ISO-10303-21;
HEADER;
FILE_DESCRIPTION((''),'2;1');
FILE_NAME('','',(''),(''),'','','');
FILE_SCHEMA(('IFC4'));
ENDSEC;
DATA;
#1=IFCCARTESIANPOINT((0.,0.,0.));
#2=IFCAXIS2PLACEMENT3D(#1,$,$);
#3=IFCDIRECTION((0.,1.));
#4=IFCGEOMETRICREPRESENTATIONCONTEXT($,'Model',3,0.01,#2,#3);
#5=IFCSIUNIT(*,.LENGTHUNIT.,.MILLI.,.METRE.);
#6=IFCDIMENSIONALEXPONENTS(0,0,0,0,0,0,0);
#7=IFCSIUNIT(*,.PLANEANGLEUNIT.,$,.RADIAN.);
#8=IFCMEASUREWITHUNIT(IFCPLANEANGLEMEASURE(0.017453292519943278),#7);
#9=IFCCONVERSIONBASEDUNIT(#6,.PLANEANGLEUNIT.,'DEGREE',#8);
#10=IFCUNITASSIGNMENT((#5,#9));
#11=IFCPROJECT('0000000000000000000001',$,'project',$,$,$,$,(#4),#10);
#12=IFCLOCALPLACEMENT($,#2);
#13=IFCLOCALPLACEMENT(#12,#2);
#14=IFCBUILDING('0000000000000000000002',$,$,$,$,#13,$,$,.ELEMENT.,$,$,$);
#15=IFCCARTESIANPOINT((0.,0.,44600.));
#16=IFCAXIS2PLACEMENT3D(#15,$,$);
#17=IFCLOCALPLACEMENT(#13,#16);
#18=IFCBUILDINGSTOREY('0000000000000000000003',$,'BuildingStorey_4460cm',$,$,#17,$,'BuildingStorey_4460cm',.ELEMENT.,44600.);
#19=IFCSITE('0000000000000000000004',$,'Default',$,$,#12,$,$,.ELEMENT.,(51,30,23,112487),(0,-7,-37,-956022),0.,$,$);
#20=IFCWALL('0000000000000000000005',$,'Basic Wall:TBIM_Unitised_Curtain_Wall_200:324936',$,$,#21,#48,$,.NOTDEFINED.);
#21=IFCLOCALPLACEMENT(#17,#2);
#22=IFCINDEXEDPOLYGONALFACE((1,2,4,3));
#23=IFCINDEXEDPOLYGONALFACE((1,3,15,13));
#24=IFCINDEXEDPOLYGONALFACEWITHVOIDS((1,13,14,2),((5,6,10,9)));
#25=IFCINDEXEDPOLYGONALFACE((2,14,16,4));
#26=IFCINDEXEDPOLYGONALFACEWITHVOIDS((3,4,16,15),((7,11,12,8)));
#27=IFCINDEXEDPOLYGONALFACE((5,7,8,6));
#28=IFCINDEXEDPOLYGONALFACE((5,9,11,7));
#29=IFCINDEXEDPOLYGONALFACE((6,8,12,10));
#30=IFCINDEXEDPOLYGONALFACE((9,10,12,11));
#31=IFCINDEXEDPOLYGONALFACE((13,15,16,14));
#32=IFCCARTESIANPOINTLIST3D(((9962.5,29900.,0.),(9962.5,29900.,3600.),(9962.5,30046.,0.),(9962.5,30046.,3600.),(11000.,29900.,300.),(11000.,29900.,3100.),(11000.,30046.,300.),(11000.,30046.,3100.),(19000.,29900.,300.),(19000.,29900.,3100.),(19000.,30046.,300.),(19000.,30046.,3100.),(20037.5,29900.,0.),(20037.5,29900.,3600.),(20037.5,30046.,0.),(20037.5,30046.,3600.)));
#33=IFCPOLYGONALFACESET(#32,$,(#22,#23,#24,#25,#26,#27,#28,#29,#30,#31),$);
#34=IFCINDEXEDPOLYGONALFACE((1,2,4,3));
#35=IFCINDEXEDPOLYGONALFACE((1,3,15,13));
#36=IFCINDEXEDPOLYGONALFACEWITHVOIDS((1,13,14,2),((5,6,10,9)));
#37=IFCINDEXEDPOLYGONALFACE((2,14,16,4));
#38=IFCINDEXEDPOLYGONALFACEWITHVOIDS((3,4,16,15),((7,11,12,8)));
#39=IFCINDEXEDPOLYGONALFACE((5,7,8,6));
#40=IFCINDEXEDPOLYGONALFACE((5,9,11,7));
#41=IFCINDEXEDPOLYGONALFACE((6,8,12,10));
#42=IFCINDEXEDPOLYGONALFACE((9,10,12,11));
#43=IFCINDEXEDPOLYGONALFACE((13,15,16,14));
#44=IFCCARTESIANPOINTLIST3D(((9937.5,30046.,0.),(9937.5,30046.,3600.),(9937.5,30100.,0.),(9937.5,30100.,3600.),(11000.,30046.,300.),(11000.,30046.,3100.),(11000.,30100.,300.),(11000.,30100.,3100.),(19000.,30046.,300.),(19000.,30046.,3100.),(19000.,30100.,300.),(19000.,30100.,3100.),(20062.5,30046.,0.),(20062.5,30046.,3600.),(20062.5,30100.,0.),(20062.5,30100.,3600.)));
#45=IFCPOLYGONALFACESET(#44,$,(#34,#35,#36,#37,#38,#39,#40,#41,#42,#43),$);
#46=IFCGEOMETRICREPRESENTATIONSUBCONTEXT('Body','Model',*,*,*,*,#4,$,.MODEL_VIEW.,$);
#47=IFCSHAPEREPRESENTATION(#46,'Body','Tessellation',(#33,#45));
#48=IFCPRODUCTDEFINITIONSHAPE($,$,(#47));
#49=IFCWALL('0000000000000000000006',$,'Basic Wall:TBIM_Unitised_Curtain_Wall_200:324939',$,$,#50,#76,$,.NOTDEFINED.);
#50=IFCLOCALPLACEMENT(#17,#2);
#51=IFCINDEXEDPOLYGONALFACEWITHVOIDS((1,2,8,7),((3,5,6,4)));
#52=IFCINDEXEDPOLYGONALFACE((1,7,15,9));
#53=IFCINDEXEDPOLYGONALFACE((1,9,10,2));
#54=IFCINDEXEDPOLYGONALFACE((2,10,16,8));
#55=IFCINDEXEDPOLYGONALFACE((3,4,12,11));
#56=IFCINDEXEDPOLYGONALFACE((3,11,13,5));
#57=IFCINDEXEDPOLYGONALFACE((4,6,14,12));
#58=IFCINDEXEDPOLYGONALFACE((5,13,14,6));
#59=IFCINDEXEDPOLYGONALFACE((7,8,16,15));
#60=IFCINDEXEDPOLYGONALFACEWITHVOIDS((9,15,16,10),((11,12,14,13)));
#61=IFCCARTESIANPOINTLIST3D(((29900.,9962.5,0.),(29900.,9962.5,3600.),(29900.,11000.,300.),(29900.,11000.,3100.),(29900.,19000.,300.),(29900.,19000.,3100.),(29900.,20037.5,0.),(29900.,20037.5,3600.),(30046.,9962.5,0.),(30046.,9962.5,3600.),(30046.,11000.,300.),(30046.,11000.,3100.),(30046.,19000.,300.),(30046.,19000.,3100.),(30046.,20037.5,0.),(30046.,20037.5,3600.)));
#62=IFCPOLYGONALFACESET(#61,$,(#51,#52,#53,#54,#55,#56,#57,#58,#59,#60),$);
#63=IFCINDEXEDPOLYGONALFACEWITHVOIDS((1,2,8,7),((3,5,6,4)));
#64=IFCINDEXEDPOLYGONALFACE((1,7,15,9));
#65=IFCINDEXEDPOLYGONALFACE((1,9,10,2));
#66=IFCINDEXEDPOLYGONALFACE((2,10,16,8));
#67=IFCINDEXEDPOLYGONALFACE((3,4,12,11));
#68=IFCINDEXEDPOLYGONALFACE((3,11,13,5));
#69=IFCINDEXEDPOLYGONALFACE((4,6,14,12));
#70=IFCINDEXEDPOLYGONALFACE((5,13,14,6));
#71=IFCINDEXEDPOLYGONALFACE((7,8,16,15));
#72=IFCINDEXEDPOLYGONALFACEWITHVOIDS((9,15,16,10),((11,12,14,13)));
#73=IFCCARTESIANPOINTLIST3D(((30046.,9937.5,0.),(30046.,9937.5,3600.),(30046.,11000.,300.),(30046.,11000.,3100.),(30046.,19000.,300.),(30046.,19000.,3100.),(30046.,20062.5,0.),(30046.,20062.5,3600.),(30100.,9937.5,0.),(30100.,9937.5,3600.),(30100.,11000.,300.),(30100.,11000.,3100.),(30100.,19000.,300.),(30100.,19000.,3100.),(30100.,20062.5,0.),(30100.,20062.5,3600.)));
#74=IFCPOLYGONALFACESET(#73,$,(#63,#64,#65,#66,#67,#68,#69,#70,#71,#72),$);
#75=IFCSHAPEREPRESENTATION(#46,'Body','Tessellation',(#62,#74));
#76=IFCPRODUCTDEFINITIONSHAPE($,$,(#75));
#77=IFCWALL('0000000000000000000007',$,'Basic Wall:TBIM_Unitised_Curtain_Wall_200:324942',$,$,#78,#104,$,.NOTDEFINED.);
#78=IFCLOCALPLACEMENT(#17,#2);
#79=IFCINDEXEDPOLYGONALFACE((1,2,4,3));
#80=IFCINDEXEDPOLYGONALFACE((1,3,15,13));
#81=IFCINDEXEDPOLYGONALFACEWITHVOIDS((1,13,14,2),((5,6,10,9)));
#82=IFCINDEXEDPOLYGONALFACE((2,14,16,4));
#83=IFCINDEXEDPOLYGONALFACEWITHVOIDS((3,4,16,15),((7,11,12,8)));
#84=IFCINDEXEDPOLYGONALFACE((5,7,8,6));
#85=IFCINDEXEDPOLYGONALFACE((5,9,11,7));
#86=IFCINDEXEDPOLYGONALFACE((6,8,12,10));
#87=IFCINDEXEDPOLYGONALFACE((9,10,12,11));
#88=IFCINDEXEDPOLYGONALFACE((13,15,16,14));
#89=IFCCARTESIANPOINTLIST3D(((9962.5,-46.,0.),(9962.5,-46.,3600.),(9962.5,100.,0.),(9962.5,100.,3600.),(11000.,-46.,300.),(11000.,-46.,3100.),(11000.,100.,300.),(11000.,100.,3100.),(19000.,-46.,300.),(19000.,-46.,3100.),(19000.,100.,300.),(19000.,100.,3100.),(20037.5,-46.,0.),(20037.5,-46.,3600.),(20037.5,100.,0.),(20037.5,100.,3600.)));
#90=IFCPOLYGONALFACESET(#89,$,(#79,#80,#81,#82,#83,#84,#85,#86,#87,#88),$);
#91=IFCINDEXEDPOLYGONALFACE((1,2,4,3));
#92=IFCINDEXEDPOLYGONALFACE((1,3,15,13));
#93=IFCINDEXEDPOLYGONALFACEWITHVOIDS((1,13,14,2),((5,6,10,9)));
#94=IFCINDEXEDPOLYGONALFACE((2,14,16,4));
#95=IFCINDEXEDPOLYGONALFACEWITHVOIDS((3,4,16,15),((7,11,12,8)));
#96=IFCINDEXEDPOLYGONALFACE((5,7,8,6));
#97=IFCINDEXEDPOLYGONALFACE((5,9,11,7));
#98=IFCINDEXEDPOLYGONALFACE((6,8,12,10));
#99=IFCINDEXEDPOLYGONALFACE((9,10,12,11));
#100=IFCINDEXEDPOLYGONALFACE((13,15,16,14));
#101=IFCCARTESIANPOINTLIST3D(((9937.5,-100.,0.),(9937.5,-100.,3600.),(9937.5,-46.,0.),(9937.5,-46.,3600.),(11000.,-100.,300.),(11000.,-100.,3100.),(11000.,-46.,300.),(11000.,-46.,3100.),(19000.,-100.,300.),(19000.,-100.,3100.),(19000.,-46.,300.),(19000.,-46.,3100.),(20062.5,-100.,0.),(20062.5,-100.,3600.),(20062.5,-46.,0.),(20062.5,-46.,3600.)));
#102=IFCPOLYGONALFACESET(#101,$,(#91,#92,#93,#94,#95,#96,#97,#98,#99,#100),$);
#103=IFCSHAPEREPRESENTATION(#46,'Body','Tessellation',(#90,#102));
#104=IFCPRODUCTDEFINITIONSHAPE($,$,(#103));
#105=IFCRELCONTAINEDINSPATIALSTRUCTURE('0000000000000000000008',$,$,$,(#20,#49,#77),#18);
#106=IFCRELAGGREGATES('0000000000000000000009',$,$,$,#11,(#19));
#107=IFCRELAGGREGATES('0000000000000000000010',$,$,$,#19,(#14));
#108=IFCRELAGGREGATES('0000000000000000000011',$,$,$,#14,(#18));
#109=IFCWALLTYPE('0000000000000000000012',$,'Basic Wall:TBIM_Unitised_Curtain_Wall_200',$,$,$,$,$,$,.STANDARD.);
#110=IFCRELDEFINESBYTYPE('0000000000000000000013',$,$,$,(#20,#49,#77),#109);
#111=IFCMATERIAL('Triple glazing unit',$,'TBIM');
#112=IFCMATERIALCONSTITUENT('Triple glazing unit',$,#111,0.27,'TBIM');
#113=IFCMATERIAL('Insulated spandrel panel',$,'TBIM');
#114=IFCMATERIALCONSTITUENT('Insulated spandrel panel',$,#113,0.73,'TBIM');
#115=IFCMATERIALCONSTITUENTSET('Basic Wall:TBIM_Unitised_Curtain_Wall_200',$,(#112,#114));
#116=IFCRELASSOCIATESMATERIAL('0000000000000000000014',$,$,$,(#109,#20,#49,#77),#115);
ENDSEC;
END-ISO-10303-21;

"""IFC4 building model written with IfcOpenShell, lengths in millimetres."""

from ifc_helpers import new_model, entity, si_unit, converted_unit, direction, frame, origin, place, context, subcontext, project, spatial, indexed_curve, outline, extrude, material, constituent, constituent_set, type_object, element, save


model = new_model("IFC4")

# Units and contexts
model_context = context("Model", 3, precision=0.01, world=origin(), true_north=direction((0.0, 1.0)))
body_context = subcontext(model_context, "Body", "Model", "MODEL_VIEW")
ifc_project = project(units=[si_unit("LENGTHUNIT", "METRE", prefix="MILLI"), converted_unit("PLANEANGLEUNIT", "DEGREE", entity("IfcPlaneAngleMeasure", 0.017453292519943278), si_unit("PLANEANGLEUNIT", "RADIAN"), dimensions=[0, 0, 0, 0, 0, 0, 0])], contexts=[model_context])

# Site, building, storey
site_placement = place(None, origin())
site = spatial("IfcSite", under=ifc_project, at=site_placement, Name="Default", CompositionType="ELEMENT", RefLatitude=(51, 30, 23, 112487), RefLongitude=(0, -7, -37, -956022), RefElevation=0.0)
building_placement = place(site_placement, origin())
building = spatial("IfcBuilding", under=site, at=building_placement, CompositionType="ELEMENT")
storey_placement = place(building_placement, frame((0.0, 0.0, 44600.0)))
storey = spatial("IfcBuildingStorey", under=building, at=storey_placement, Name="BuildingStorey_4460cm", LongName="BuildingStorey_4460cm", CompositionType="ELEMENT", Elevation=44600.0)

# Walls, openings
ifc_material_1 = material(Name="Triple glazing unit", Category="TBIM")
ifc_constituent_1 = constituent(ifc_material_1, Name="Triple glazing unit", Category="TBIM", fraction=0.27)
ifc_material_2 = material(Name="Insulated spandrel panel", Category="TBIM")
ifc_constituent_2 = constituent(ifc_material_2, Name="Insulated spandrel panel", Category="TBIM", fraction=0.73)
ifc_constituent_set_1 = constituent_set(constituents=[ifc_constituent_1, ifc_constituent_2], Name="Basic Wall:TBIM_Unitised_Curtain_Wall_200")
wall_type_1 = type_object("IfcWallType", Name="Basic Wall:TBIM_Unitised_Curtain_Wall_200", PredefinedType="STANDARD", material=ifc_constituent_set_1)
wall_1_placement = place(storey_placement, frame((9937.5, 30000.0, 0.0)))
wall_1 = element("IfcWall", 1, at=wall_1_placement, inside=storey, type_object=wall_type_1, material=ifc_constituent_set_1, Name="Basic Wall:TBIM_Unitised_Curtain_Wall_200:324936", PredefinedType="NOTDEFINED", context=body_context, shape_type="SweptSolid", body=[
    extrude(outline(indexed_curve([(-1800.0, -5037.5), (1800.0, -5037.5), (1800.0, -4937.5), (1800.0, 4937.5), (1800.0, 5037.5), (-1800.0, 5037.5), (-1800.0, 4937.5), (-1800.0, -4937.5), (-1800.0, -5037.5)], self_intersect=False), holes=[indexed_curve([(1300.0, -4000.0), (-1500.0, -4000.0), (-1500.0, 4000.0), (1300.0, 4000.0), (1300.0, -4000.0)], self_intersect=False)]), frame((5062.5, -100.0, 1800.0), z_axis=(0.0, 1.0, 0.0), x_axis=(0.0, 0.0, 1.0)), (0.0, 0.0, 1.0), 146.0),
    extrude(outline(indexed_curve([(-1800.0, -5062.5), (1800.0, -5062.5), (1800.0, 5062.5), (-1800.0, 5062.5), (-1800.0, -5062.5)], self_intersect=False), holes=[indexed_curve([(-1500.0, -4000.0), (-1500.0, 4000.0), (1300.0, 4000.0), (1300.0, -4000.0), (-1500.0, -4000.0)], self_intersect=False)]), frame((5062.5, 46.0, 1800.0), z_axis=(0.0, 1.0, 0.0), x_axis=(0.0, 0.0, 1.0)), (0.0, 0.0, 1.0), 54.0),
])
opening_1_placement = place(wall_1_placement, frame((1062.5, -100.0, 300.0)))
element("IfcOpeningElement", 2, at=opening_1_placement, cuts=wall_1, PredefinedType="OPENING", context=body_context, shape_type="SweptSolid", body=[
    extrude(outline(indexed_curve([(2800.0, 0.0), (2800.0, 8000.0), (0.0, 8000.0), (0.0, 0.0), (2800.0, 0.0)], self_intersect=False)), frame((0.0, 0.0, 0.0), z_axis=(0.0, 1.0, 0.0), x_axis=(0.0, 0.0, 1.0)), (0.0, 0.0, 1.0), 200.0),
])
wall_2_placement = place(storey_placement, frame((30000.0, 9937.5, 0.0), z_axis=(0.0, 0.0, 1.0), x_axis=(0.0, 1.0, 0.0)))
wall_2 = element("IfcWall", 3, at=wall_2_placement, inside=storey, type_object=wall_type_1, material=ifc_constituent_set_1, Name="Basic Wall:TBIM_Unitised_Curtain_Wall_200:324939", PredefinedType="NOTDEFINED", context=body_context, shape_type="SweptSolid", body=[
    extrude(outline(indexed_curve([(-5037.5, -1800.0), (-4937.5, -1800.0), (4937.5, -1800.0), (5037.5, -1800.0), (5037.5, 1800.0), (4937.5, 1800.0), (-4937.5, 1800.0), (-5037.5, 1800.0), (-5037.5, -1800.0)], self_intersect=False), holes=[indexed_curve([(-4000.0, 1300.0), (4000.0, 1300.0), (4000.0, -1500.0), (-4000.0, -1500.0), (-4000.0, 1300.0)], self_intersect=False)]), frame((5062.5, 100.0, 1800.0), z_axis=(0.0, -1.0, 0.0), x_axis=(1.0, 0.0, 0.0)), (0.0, 0.0, 1.0), 146.0),
    extrude(outline(indexed_curve([(-1800.0, -5062.5), (1800.0, -5062.5), (1800.0, 5062.5), (-1800.0, 5062.5), (-1800.0, -5062.5)], self_intersect=False), holes=[indexed_curve([(1300.0, 4000.0), (1300.0, -4000.0), (-1500.0, -4000.0), (-1500.0, 4000.0), (1300.0, 4000.0)], self_intersect=False)]), frame((5062.5, -46.0, 1800.0), z_axis=(0.0, -1.0, 0.0), x_axis=(0.0, 0.0, 1.0)), (0.0, 0.0, 1.0), 54.0),
])
opening_2_placement = place(wall_2_placement, frame((1062.5, -100.0, 300.0)))
element("IfcOpeningElement", 4, at=opening_2_placement, cuts=wall_2, PredefinedType="OPENING", context=body_context, shape_type="SweptSolid", body=[
    extrude(outline(indexed_curve([(2800.0, 0.0), (2800.0, 8000.0), (0.0, 8000.0), (0.0, 0.0), (2800.0, 0.0)], self_intersect=False)), frame((0.0, 0.0, 0.0), z_axis=(0.0, 1.0, 0.0), x_axis=(0.0, 0.0, 1.0)), (0.0, 0.0, 1.0), 200.0),
])
wall_3_placement = place(storey_placement, frame((9937.5, 0.0, 0.0)))
wall_3 = element("IfcWall", 5, at=wall_3_placement, inside=storey, type_object=wall_type_1, material=ifc_constituent_set_1, Name="Basic Wall:TBIM_Unitised_Curtain_Wall_200:324942", PredefinedType="NOTDEFINED", context=body_context, shape_type="SweptSolid", body=[
    extrude(outline(indexed_curve([(-1800.0, -5037.5), (1800.0, -5037.5), (1800.0, 5037.5), (-1800.0, 5037.5), (-1800.0, -5037.5)], self_intersect=False), holes=[indexed_curve([(-1500.0, -4000.0), (-1500.0, 4000.0), (1300.0, 4000.0), (1300.0, -4000.0), (-1500.0, -4000.0)], self_intersect=False)]), frame((5062.5, -46.0, 1800.0), z_axis=(0.0, 1.0, 0.0), x_axis=(0.0, 0.0, 1.0)), (0.0, 0.0, 1.0), 146.0),
    extrude(outline(indexed_curve([(-1800.0, -5062.5), (1800.0, -5062.5), (1800.0, 5062.5), (-1800.0, 5062.5), (-1800.0, -5062.5)], self_intersect=False), holes=[indexed_curve([(1300.0, -4000.0), (-1500.0, -4000.0), (-1500.0, 4000.0), (1300.0, 4000.0), (1300.0, -4000.0)], self_intersect=False)]), frame((5062.5, -100.0, 1800.0), z_axis=(0.0, 1.0, 0.0), x_axis=(0.0, 0.0, 1.0)), (0.0, 0.0, 1.0), 54.0),
])
opening_3_placement = place(wall_3_placement, frame((1062.5, -100.0, 300.0)))
element("IfcOpeningElement", 6, at=opening_3_placement, cuts=wall_3, PredefinedType="OPENING", context=body_context, shape_type="SweptSolid", body=[
    extrude(outline(indexed_curve([(2800.0, 0.0), (2800.0, 8000.0), (0.0, 8000.0), (0.0, 0.0), (2800.0, 0.0)], self_intersect=False)), frame((0.0, 0.0, 0.0), z_axis=(0.0, 1.0, 0.0), x_axis=(0.0, 0.0, 1.0)), (0.0, 0.0, 1.0), 200.0),
])

save(model, "model.ifc")
